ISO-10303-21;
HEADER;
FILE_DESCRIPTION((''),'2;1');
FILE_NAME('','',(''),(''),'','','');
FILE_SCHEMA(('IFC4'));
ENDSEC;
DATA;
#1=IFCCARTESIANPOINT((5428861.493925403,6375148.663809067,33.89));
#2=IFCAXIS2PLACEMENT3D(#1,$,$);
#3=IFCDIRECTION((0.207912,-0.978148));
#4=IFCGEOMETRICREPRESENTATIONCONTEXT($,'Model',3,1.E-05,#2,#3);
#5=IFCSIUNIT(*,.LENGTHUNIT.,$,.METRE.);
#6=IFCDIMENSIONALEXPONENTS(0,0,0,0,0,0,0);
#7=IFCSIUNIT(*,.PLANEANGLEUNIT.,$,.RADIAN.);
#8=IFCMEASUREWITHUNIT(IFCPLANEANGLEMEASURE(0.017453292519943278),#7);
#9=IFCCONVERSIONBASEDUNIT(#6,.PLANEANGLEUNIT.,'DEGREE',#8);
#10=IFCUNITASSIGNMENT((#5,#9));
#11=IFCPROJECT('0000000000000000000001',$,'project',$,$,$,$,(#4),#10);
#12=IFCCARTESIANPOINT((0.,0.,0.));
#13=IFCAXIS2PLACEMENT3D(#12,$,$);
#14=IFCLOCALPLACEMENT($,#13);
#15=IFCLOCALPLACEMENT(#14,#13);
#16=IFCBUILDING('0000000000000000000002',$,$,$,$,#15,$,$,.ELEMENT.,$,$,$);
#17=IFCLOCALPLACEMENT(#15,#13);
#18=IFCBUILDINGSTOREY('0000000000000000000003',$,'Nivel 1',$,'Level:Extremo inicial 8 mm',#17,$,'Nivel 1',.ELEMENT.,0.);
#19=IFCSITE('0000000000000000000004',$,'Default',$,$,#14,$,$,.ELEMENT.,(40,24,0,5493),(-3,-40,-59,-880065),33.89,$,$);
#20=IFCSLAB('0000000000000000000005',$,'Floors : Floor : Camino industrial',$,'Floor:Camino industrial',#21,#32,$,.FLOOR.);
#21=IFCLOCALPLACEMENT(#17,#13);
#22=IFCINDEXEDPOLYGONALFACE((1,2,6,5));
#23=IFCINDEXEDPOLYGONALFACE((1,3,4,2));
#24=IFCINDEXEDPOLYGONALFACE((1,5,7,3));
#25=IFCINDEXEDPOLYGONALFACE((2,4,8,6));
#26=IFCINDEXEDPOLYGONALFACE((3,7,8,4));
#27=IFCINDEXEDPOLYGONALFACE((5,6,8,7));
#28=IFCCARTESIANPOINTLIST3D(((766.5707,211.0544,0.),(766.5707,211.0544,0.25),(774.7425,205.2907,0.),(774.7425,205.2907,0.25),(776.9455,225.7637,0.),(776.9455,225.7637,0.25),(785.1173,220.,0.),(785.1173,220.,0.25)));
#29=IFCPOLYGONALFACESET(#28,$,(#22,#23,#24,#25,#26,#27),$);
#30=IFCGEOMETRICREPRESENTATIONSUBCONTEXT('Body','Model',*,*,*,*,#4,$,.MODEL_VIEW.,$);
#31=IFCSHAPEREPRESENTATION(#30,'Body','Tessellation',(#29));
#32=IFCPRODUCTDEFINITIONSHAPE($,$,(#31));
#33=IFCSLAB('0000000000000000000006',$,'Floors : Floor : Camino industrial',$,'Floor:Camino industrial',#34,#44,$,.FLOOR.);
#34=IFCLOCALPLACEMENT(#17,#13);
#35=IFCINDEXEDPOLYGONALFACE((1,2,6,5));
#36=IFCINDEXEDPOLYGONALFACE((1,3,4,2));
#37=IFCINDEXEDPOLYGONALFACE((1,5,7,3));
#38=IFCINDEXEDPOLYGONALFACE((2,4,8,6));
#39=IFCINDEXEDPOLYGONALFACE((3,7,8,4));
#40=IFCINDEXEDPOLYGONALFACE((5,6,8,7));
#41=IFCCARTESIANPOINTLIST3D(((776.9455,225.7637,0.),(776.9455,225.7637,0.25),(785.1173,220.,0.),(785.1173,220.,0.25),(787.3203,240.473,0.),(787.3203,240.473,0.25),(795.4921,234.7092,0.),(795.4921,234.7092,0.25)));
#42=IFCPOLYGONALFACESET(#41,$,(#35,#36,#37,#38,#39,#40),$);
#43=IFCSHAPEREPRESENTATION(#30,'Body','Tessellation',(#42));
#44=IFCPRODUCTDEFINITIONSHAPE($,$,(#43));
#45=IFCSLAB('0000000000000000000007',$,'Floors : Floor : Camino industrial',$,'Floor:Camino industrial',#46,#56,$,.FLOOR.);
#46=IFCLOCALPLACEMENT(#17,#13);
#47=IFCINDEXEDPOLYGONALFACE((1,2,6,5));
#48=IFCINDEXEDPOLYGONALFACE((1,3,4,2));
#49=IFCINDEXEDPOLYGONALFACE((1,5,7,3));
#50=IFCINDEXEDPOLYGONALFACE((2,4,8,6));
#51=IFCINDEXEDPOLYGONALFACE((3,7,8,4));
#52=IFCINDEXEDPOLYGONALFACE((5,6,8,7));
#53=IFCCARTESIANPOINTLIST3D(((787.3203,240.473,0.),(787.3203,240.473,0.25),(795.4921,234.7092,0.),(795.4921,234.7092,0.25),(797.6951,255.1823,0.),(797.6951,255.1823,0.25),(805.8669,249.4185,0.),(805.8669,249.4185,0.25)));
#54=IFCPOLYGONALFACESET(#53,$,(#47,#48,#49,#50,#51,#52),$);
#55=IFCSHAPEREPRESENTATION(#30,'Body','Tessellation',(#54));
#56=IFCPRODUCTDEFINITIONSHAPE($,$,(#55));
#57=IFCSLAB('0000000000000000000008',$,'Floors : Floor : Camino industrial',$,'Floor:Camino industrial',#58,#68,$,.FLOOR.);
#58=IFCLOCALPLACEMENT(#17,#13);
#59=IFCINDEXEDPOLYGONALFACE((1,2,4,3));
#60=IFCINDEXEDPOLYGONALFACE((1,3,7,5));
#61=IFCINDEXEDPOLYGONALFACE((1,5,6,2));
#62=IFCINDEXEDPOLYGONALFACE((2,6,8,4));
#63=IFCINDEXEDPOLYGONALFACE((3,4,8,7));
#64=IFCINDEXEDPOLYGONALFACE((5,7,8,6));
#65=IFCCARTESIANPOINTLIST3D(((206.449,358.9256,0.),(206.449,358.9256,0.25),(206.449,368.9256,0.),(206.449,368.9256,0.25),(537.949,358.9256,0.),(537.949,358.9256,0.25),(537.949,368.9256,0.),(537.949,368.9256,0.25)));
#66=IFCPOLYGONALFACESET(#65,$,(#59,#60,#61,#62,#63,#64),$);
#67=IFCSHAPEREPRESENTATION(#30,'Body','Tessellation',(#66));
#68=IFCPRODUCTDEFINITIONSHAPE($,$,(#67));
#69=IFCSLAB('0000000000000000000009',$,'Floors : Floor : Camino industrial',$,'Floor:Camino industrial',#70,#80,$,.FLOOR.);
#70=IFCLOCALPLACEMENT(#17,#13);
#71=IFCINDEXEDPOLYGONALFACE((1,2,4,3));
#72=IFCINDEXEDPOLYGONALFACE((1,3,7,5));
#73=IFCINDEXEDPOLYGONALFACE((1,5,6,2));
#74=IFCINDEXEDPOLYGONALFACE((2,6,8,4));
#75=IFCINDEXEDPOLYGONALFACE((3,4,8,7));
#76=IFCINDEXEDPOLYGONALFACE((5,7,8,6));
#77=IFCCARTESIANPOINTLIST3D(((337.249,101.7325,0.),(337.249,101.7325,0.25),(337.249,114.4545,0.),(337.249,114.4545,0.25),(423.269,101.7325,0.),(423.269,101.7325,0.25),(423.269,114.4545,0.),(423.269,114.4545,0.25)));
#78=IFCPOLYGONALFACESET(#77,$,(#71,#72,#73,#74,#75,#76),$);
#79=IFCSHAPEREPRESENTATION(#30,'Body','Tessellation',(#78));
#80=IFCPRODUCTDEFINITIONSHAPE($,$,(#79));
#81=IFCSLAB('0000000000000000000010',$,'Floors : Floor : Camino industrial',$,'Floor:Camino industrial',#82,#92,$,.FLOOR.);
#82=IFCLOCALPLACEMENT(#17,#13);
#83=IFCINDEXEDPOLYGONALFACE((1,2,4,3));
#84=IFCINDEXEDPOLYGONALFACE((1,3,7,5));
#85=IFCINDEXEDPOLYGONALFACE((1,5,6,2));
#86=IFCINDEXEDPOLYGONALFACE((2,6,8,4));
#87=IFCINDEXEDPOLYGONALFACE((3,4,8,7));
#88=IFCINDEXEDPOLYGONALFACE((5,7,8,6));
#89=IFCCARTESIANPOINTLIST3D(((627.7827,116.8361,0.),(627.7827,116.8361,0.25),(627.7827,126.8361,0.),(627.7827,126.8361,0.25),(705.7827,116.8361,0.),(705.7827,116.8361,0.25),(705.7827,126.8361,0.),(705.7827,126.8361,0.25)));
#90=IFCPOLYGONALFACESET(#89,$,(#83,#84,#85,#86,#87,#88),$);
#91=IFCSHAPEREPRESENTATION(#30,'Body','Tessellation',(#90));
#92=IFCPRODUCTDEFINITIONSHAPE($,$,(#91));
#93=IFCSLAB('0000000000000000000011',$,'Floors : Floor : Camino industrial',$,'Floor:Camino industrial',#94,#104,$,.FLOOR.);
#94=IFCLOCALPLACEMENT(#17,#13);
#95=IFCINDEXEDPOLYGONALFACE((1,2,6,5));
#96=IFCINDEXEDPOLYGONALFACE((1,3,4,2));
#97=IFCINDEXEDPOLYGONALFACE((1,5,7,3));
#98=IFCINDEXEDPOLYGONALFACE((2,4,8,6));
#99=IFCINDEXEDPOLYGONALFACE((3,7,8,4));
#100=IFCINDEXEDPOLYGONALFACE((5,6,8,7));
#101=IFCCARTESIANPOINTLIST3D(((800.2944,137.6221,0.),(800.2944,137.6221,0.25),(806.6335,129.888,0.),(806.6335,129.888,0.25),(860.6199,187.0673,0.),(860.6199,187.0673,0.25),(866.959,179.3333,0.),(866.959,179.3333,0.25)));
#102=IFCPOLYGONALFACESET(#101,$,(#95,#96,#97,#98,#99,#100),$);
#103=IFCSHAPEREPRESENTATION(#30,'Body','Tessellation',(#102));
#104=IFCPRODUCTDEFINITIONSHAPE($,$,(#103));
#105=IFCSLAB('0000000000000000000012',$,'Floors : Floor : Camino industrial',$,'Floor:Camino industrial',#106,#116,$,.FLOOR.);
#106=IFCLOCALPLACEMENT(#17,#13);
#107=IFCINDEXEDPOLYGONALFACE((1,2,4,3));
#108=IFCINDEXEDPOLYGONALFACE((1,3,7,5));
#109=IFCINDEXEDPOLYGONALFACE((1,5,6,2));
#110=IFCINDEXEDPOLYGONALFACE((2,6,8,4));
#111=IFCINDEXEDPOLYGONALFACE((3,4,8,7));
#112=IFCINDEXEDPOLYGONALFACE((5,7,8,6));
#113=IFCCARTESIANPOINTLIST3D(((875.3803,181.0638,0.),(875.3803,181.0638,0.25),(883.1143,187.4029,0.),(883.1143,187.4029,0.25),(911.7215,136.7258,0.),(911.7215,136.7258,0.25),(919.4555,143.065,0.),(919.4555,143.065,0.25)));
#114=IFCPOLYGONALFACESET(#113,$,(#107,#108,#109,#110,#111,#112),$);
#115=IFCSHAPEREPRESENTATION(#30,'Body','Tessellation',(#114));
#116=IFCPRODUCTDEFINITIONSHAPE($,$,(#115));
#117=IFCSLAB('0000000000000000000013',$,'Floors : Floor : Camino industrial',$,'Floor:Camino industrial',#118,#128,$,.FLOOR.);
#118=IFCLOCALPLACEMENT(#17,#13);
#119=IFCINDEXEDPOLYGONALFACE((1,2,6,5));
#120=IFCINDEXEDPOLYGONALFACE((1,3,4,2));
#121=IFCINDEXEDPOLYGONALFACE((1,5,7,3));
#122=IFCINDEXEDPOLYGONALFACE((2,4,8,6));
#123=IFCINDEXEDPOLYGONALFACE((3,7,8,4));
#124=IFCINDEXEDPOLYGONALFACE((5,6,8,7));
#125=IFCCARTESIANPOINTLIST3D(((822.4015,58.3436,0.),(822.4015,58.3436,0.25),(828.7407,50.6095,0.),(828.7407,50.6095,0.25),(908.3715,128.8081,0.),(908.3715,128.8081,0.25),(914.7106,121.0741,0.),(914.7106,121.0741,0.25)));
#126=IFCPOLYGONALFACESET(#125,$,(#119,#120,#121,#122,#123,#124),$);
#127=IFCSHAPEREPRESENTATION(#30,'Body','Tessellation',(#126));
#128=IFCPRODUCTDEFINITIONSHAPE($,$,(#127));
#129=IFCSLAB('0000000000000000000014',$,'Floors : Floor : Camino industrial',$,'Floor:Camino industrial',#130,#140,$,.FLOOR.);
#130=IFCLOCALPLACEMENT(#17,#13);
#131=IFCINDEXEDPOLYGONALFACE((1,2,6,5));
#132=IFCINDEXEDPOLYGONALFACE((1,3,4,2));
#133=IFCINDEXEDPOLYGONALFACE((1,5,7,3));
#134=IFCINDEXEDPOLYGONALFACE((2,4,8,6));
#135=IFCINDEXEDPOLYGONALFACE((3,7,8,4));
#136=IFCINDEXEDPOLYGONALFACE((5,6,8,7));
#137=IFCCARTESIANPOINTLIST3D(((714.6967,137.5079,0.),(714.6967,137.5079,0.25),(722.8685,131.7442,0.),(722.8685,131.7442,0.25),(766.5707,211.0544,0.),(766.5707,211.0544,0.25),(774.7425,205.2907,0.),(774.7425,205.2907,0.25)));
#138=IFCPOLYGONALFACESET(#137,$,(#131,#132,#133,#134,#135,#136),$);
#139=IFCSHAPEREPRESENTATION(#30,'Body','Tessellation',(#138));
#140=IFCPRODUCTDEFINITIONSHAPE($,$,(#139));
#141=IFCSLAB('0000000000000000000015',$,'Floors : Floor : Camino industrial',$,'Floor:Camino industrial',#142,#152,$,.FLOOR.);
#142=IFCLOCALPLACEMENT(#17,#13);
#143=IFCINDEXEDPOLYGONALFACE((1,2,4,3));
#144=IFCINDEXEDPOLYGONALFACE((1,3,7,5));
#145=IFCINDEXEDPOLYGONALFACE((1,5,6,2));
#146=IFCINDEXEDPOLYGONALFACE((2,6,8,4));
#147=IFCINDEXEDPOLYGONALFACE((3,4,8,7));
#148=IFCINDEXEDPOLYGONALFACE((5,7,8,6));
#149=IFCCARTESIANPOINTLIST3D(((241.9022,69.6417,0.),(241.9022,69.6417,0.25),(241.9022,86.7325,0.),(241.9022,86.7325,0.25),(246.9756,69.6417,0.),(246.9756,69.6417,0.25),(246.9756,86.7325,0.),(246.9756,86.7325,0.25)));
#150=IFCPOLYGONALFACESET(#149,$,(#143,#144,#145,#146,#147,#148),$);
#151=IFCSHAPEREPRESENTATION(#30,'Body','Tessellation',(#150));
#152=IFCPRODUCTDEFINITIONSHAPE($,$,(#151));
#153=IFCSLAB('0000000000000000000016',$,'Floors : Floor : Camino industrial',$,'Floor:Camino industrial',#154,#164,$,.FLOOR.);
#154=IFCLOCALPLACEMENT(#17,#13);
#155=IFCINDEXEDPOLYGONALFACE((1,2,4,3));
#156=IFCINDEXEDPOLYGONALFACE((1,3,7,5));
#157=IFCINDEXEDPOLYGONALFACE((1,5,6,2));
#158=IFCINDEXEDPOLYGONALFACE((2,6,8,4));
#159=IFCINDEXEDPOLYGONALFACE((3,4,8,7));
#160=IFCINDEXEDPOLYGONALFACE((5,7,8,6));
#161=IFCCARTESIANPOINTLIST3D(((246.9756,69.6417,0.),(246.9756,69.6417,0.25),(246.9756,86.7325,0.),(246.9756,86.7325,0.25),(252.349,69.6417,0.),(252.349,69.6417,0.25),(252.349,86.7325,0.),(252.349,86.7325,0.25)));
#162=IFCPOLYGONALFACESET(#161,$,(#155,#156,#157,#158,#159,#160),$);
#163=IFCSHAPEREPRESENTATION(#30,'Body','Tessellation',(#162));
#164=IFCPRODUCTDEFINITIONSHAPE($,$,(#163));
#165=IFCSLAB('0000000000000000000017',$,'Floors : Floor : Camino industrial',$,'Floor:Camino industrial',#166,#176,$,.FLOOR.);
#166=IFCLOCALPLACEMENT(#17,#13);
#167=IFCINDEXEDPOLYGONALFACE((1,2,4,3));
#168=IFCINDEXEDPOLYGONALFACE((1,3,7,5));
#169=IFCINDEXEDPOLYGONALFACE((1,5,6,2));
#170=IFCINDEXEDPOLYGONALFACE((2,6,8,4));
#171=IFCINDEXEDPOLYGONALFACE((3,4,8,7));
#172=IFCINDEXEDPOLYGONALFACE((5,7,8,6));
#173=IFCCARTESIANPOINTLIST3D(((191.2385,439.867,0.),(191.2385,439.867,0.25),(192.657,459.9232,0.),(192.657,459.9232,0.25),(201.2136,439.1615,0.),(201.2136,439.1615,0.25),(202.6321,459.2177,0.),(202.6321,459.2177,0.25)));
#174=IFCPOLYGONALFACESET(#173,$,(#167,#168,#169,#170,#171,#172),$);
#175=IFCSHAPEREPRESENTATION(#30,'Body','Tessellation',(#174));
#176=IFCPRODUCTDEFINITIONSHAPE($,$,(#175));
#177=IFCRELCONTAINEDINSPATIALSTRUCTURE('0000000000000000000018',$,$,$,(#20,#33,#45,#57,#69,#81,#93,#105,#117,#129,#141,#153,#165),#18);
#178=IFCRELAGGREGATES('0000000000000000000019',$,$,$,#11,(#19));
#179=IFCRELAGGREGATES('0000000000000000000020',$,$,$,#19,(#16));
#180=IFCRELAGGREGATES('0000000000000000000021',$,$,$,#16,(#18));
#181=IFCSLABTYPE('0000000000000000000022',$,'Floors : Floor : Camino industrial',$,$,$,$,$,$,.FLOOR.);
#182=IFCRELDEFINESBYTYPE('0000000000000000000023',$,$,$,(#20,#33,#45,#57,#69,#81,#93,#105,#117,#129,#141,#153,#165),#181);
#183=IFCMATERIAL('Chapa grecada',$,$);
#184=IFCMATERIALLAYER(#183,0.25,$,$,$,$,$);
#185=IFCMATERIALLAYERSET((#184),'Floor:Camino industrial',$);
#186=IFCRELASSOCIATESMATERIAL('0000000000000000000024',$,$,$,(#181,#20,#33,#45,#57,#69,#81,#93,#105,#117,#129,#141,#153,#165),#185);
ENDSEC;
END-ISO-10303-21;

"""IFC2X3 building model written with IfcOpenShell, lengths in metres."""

from ifc_helpers import new_model, entity, si_unit, converted_unit, direction, frame, frame_2d, origin, place, context, subcontext, project, spatial, rectangle, extrude, material, layer, layer_set, layer_usage, type_object, element, save


model = new_model("IFC2X3")

# Units and contexts
model_context = context("Model", 3, precision=1e-05, world=frame((5428861.493925403, 6375148.663809067, 33.89)), true_north=direction((0.207912, -0.978148)))
body_context = subcontext(model_context, "Body", "Model", "MODEL_VIEW")
ifc_project = project(units=[si_unit("LENGTHUNIT", "METRE"), converted_unit("PLANEANGLEUNIT", "DEGREE", entity("IfcPlaneAngleMeasure", 0.017453292519943278), si_unit("PLANEANGLEUNIT", "RADIAN"), dimensions=[0, 0, 0, 0, 0, 0, 0])], contexts=[model_context])

# Site, building, storey
site_placement = place(None, origin())
site = spatial("IfcSite", under=ifc_project, at=site_placement, Name="Default", CompositionType="ELEMENT", RefLatitude=(40, 24, 0, 5493), RefLongitude=(-3, -40, -59, -880065), RefElevation=33.89)
building_placement = place(site_placement, origin())
building = spatial("IfcBuilding", under=site, at=building_placement, CompositionType="ELEMENT")
storey_placement = place(building_placement, origin())
storey = spatial("IfcBuildingStorey", under=building, at=storey_placement, Name="Nivel 1", ObjectType="Level:Extremo inicial 8 mm", LongName="Nivel 1", CompositionType="ELEMENT", Elevation=0.0)

# Slabs
ifc_material = material(Name="Chapa grecada")
ifc_layer = layer(ifc_material, 0.25)
ifc_layer_set = layer_set([ifc_layer], Name="Floor:Camino industrial")
slab_type = type_object("IfcSlabType", Name="Floors : Floor : Camino industrial", PredefinedType="FLOOR", material=ifc_layer_set)
ifc_layer_usage_1 = layer_usage(ifc_layer_set, "AXIS3", "POSITIVE", 0.0)
slab_1_placement = place(storey_placement, origin())
element("IfcSlab", 1, at=slab_1_placement, inside=storey, type_object=slab_type, material=ifc_layer_usage_1, Name="Floors : Floor : Camino industrial", ObjectType="Floor:Camino industrial", PredefinedType="FLOOR", context=body_context, shape_type="SweptSolid", body=[
    extrude(rectangle(XDim=10.0, YDim=18.0, at=frame_2d((0.0, 0.0), x_axis=(1.0, 0.0))), frame((775.844, 215.5272, 0.25), z_axis=(0.0, 0.0, -1.0), x_axis=(0.817183, -0.576378, 0.0)), (0.0, 0.0, 1.0), 0.25),
])
ifc_layer_usage_2 = layer_usage(ifc_layer_set, "AXIS3", "POSITIVE", 0.0)
slab_2_placement = place(storey_placement, origin())
element("IfcSlab", 2, at=slab_2_placement, inside=storey, type_object=slab_type, material=ifc_layer_usage_2, Name="Floors : Floor : Camino industrial", ObjectType="Floor:Camino industrial", PredefinedType="FLOOR", context=body_context, shape_type="SweptSolid", body=[
    extrude(rectangle(XDim=10.0, YDim=18.0, at=frame_2d((0.0, 0.0), x_axis=(1.0, 0.0))), frame((786.2188, 230.2365, 0.25), z_axis=(0.0, 0.0, -1.0), x_axis=(0.817183, -0.576378, 0.0)), (0.0, 0.0, 1.0), 0.25),
])
ifc_layer_usage_3 = layer_usage(ifc_layer_set, "AXIS3", "POSITIVE", 0.0)
slab_3_placement = place(storey_placement, origin())
element("IfcSlab", 3, at=slab_3_placement, inside=storey, type_object=slab_type, material=ifc_layer_usage_3, Name="Floors : Floor : Camino industrial", ObjectType="Floor:Camino industrial", PredefinedType="FLOOR", context=body_context, shape_type="SweptSolid", body=[
    extrude(rectangle(XDim=10.0, YDim=18.0, at=frame_2d((0.0, 0.0), x_axis=(1.0, 0.0))), frame((796.5936, 244.9458, 0.25), z_axis=(0.0, 0.0, -1.0), x_axis=(0.817183, -0.576378, 0.0)), (0.0, 0.0, 1.0), 0.25),
])
ifc_layer_usage_4 = layer_usage(ifc_layer_set, "AXIS3", "POSITIVE", 0.0)
slab_4_placement = place(storey_placement, origin())
element("IfcSlab", 4, at=slab_4_placement, inside=storey, type_object=slab_type, material=ifc_layer_usage_4, Name="Floors : Floor : Camino industrial", ObjectType="Floor:Camino industrial", PredefinedType="FLOOR", context=body_context, shape_type="SweptSolid", body=[
    extrude(rectangle(XDim=10.0, YDim=331.5, at=frame_2d((0.0, 0.0), x_axis=(1.0, 0.0))), frame((372.199, 363.9256, 0.25), z_axis=(0.0, 0.0, -1.0), x_axis=(0.0, 1.0, 0.0)), (0.0, 0.0, 1.0), 0.25),
])
ifc_layer_usage_5 = layer_usage(ifc_layer_set, "AXIS3", "POSITIVE", 0.0)
slab_5_placement = place(storey_placement, origin())
element("IfcSlab", 5, at=slab_5_placement, inside=storey, type_object=slab_type, material=ifc_layer_usage_5, Name="Floors : Floor : Camino industrial", ObjectType="Floor:Camino industrial", PredefinedType="FLOOR", context=body_context, shape_type="SweptSolid", body=[
    extrude(rectangle(XDim=12.722, YDim=86.02, at=frame_2d((0.0, 0.0), x_axis=(1.0, 0.0))), frame((380.259, 108.0935, 0.25), z_axis=(0.0, 0.0, -1.0), x_axis=(0.0, 1.0, 0.0)), (0.0, 0.0, 1.0), 0.25),
])
ifc_layer_usage_6 = layer_usage(ifc_layer_set, "AXIS3", "POSITIVE", 0.0)
slab_6_placement = place(storey_placement, origin())
element("IfcSlab", 6, at=slab_6_placement, inside=storey, type_object=slab_type, material=ifc_layer_usage_6, Name="Floors : Floor : Camino industrial", ObjectType="Floor:Camino industrial", PredefinedType="FLOOR", context=body_context, shape_type="SweptSolid", body=[
    extrude(rectangle(XDim=10.0, YDim=78.0, at=frame_2d((0.0, 0.0), x_axis=(1.0, 0.0))), frame((666.7827, 121.8361, 0.25), z_axis=(0.0, 0.0, -1.0), x_axis=(0.0, 1.0, 0.0)), (0.0, 0.0, 1.0), 0.25),
])
ifc_layer_usage_7 = layer_usage(ifc_layer_set, "AXIS3", "POSITIVE", 0.0)
slab_7_placement = place(storey_placement, origin())
element("IfcSlab", 7, at=slab_7_placement, inside=storey, type_object=slab_type, material=ifc_layer_usage_7, Name="Floors : Floor : Camino industrial", ObjectType="Floor:Camino industrial", PredefinedType="FLOOR", context=body_context, shape_type="SweptSolid", body=[
    extrude(rectangle(XDim=78.0, YDim=10.0, at=frame_2d((0.0, 0.0), x_axis=(1.0, 0.0))), frame((833.6267, 158.4777, 0.25), z_axis=(0.0, 0.0, -1.0), x_axis=(-0.773404, -0.633914, 0.0)), (0.0, 0.0, 1.0), 0.25),
])
ifc_layer_usage_8 = layer_usage(ifc_layer_set, "AXIS3", "POSITIVE", 0.0)
slab_8_placement = place(storey_placement, origin())
element("IfcSlab", 8, at=slab_8_placement, inside=storey, type_object=slab_type, material=ifc_layer_usage_8, Name="Floors : Floor : Camino industrial", ObjectType="Floor:Camino industrial", PredefinedType="FLOOR", context=body_context, shape_type="SweptSolid", body=[
    extrude(rectangle(XDim=57.3283, YDim=10.0, at=frame_2d((0.0, 0.0), x_axis=(1.0, 0.0))), frame((897.4179, 162.0644, 0.25), z_axis=(0.0, 0.0, -1.0), x_axis=(0.633914, -0.773404, 0.0)), (0.0, 0.0, 1.0), 0.25),
])
ifc_layer_usage_9 = layer_usage(ifc_layer_set, "AXIS3", "POSITIVE", 0.0)
slab_9_placement = place(storey_placement, origin())
element("IfcSlab", 9, at=slab_9_placement, inside=storey, type_object=slab_type, material=ifc_layer_usage_9, Name="Floors : Floor : Camino industrial", ObjectType="Floor:Camino industrial", PredefinedType="FLOOR", context=body_context, shape_type="SweptSolid", body=[
    extrude(rectangle(XDim=10.0, YDim=111.1579, at=frame_2d((0.0, 0.0), x_axis=(1.0, 0.0))), frame((868.5561, 89.7088, 0.25), z_axis=(0.0, 0.0, -1.0), x_axis=(0.633914, -0.773404, 0.0)), (0.0, 0.0, 1.0), 0.25),
])
ifc_layer_usage_10 = layer_usage(ifc_layer_set, "AXIS3", "POSITIVE", 0.0)
slab_10_placement = place(storey_placement, origin())
element("IfcSlab", 10, at=slab_10_placement, inside=storey, type_object=slab_type, material=ifc_layer_usage_10, Name="Floors : Floor : Camino industrial", ObjectType="Floor:Camino industrial", PredefinedType="FLOOR", context=body_context, shape_type="SweptSolid", body=[
    extrude(rectangle(XDim=90.0, YDim=10.0, at=frame_2d((0.0, 0.0), x_axis=(1.0, 0.0))), frame((744.7196, 171.3993, 0.25), z_axis=(0.0, 0.0, -1.0), x_axis=(-0.576378, -0.817183, 0.0)), (0.0, 0.0, 1.0), 0.25),
])
ifc_layer_usage_11 = layer_usage(ifc_layer_set, "AXIS3", "POSITIVE", 0.0)
slab_11_placement = place(storey_placement, origin())
element("IfcSlab", 11, at=slab_11_placement, inside=storey, type_object=slab_type, material=ifc_layer_usage_11, Name="Floors : Floor : Camino industrial", ObjectType="Floor:Camino industrial", PredefinedType="FLOOR", context=body_context, shape_type="SweptSolid", body=[
    extrude(rectangle(XDim=17.0908, YDim=5.0734, at=frame_2d((0.0, 0.0), x_axis=(1.0, 0.0))), frame((244.4389, 78.1871, 0.25), z_axis=(0.0, 0.0, -1.0), x_axis=(0.0, 1.0, 0.0)), (0.0, 0.0, 1.0), 0.25),
])
ifc_layer_usage_12 = layer_usage(ifc_layer_set, "AXIS3", "POSITIVE", 0.0)
slab_12_placement = place(storey_placement, origin())
element("IfcSlab", 12, at=slab_12_placement, inside=storey, type_object=slab_type, material=ifc_layer_usage_12, Name="Floors : Floor : Camino industrial", ObjectType="Floor:Camino industrial", PredefinedType="FLOOR", context=body_context, shape_type="SweptSolid", body=[
    extrude(rectangle(XDim=17.0908, YDim=5.3734, at=frame_2d((0.0, 0.0), x_axis=(1.0, 0.0))), frame((249.6623, 78.1871, 0.25), z_axis=(0.0, 0.0, -1.0), x_axis=(0.0, 1.0, 0.0)), (0.0, 0.0, 1.0), 0.25),
])
ifc_layer_usage_13 = layer_usage(ifc_layer_set, "AXIS3", "POSITIVE", 0.0)
slab_13_placement = place(storey_placement, origin())
element("IfcSlab", 13, at=slab_13_placement, inside=storey, type_object=slab_type, material=ifc_layer_usage_13, Name="Floors : Floor : Camino industrial", ObjectType="Floor:Camino industrial", PredefinedType="FLOOR", context=body_context, shape_type="SweptSolid", body=[
    extrude(rectangle(XDim=20.1063, YDim=10.0, at=frame_2d((0.0, 0.0), x_axis=(1.0, 0.0))), frame((196.9353, 449.5424, 0.25), z_axis=(0.0, 0.0, -1.0), x_axis=(-0.070551, -0.997508, 0.0)), (0.0, 0.0, 1.0), 0.25),
])

save(model, "model.ifc")
